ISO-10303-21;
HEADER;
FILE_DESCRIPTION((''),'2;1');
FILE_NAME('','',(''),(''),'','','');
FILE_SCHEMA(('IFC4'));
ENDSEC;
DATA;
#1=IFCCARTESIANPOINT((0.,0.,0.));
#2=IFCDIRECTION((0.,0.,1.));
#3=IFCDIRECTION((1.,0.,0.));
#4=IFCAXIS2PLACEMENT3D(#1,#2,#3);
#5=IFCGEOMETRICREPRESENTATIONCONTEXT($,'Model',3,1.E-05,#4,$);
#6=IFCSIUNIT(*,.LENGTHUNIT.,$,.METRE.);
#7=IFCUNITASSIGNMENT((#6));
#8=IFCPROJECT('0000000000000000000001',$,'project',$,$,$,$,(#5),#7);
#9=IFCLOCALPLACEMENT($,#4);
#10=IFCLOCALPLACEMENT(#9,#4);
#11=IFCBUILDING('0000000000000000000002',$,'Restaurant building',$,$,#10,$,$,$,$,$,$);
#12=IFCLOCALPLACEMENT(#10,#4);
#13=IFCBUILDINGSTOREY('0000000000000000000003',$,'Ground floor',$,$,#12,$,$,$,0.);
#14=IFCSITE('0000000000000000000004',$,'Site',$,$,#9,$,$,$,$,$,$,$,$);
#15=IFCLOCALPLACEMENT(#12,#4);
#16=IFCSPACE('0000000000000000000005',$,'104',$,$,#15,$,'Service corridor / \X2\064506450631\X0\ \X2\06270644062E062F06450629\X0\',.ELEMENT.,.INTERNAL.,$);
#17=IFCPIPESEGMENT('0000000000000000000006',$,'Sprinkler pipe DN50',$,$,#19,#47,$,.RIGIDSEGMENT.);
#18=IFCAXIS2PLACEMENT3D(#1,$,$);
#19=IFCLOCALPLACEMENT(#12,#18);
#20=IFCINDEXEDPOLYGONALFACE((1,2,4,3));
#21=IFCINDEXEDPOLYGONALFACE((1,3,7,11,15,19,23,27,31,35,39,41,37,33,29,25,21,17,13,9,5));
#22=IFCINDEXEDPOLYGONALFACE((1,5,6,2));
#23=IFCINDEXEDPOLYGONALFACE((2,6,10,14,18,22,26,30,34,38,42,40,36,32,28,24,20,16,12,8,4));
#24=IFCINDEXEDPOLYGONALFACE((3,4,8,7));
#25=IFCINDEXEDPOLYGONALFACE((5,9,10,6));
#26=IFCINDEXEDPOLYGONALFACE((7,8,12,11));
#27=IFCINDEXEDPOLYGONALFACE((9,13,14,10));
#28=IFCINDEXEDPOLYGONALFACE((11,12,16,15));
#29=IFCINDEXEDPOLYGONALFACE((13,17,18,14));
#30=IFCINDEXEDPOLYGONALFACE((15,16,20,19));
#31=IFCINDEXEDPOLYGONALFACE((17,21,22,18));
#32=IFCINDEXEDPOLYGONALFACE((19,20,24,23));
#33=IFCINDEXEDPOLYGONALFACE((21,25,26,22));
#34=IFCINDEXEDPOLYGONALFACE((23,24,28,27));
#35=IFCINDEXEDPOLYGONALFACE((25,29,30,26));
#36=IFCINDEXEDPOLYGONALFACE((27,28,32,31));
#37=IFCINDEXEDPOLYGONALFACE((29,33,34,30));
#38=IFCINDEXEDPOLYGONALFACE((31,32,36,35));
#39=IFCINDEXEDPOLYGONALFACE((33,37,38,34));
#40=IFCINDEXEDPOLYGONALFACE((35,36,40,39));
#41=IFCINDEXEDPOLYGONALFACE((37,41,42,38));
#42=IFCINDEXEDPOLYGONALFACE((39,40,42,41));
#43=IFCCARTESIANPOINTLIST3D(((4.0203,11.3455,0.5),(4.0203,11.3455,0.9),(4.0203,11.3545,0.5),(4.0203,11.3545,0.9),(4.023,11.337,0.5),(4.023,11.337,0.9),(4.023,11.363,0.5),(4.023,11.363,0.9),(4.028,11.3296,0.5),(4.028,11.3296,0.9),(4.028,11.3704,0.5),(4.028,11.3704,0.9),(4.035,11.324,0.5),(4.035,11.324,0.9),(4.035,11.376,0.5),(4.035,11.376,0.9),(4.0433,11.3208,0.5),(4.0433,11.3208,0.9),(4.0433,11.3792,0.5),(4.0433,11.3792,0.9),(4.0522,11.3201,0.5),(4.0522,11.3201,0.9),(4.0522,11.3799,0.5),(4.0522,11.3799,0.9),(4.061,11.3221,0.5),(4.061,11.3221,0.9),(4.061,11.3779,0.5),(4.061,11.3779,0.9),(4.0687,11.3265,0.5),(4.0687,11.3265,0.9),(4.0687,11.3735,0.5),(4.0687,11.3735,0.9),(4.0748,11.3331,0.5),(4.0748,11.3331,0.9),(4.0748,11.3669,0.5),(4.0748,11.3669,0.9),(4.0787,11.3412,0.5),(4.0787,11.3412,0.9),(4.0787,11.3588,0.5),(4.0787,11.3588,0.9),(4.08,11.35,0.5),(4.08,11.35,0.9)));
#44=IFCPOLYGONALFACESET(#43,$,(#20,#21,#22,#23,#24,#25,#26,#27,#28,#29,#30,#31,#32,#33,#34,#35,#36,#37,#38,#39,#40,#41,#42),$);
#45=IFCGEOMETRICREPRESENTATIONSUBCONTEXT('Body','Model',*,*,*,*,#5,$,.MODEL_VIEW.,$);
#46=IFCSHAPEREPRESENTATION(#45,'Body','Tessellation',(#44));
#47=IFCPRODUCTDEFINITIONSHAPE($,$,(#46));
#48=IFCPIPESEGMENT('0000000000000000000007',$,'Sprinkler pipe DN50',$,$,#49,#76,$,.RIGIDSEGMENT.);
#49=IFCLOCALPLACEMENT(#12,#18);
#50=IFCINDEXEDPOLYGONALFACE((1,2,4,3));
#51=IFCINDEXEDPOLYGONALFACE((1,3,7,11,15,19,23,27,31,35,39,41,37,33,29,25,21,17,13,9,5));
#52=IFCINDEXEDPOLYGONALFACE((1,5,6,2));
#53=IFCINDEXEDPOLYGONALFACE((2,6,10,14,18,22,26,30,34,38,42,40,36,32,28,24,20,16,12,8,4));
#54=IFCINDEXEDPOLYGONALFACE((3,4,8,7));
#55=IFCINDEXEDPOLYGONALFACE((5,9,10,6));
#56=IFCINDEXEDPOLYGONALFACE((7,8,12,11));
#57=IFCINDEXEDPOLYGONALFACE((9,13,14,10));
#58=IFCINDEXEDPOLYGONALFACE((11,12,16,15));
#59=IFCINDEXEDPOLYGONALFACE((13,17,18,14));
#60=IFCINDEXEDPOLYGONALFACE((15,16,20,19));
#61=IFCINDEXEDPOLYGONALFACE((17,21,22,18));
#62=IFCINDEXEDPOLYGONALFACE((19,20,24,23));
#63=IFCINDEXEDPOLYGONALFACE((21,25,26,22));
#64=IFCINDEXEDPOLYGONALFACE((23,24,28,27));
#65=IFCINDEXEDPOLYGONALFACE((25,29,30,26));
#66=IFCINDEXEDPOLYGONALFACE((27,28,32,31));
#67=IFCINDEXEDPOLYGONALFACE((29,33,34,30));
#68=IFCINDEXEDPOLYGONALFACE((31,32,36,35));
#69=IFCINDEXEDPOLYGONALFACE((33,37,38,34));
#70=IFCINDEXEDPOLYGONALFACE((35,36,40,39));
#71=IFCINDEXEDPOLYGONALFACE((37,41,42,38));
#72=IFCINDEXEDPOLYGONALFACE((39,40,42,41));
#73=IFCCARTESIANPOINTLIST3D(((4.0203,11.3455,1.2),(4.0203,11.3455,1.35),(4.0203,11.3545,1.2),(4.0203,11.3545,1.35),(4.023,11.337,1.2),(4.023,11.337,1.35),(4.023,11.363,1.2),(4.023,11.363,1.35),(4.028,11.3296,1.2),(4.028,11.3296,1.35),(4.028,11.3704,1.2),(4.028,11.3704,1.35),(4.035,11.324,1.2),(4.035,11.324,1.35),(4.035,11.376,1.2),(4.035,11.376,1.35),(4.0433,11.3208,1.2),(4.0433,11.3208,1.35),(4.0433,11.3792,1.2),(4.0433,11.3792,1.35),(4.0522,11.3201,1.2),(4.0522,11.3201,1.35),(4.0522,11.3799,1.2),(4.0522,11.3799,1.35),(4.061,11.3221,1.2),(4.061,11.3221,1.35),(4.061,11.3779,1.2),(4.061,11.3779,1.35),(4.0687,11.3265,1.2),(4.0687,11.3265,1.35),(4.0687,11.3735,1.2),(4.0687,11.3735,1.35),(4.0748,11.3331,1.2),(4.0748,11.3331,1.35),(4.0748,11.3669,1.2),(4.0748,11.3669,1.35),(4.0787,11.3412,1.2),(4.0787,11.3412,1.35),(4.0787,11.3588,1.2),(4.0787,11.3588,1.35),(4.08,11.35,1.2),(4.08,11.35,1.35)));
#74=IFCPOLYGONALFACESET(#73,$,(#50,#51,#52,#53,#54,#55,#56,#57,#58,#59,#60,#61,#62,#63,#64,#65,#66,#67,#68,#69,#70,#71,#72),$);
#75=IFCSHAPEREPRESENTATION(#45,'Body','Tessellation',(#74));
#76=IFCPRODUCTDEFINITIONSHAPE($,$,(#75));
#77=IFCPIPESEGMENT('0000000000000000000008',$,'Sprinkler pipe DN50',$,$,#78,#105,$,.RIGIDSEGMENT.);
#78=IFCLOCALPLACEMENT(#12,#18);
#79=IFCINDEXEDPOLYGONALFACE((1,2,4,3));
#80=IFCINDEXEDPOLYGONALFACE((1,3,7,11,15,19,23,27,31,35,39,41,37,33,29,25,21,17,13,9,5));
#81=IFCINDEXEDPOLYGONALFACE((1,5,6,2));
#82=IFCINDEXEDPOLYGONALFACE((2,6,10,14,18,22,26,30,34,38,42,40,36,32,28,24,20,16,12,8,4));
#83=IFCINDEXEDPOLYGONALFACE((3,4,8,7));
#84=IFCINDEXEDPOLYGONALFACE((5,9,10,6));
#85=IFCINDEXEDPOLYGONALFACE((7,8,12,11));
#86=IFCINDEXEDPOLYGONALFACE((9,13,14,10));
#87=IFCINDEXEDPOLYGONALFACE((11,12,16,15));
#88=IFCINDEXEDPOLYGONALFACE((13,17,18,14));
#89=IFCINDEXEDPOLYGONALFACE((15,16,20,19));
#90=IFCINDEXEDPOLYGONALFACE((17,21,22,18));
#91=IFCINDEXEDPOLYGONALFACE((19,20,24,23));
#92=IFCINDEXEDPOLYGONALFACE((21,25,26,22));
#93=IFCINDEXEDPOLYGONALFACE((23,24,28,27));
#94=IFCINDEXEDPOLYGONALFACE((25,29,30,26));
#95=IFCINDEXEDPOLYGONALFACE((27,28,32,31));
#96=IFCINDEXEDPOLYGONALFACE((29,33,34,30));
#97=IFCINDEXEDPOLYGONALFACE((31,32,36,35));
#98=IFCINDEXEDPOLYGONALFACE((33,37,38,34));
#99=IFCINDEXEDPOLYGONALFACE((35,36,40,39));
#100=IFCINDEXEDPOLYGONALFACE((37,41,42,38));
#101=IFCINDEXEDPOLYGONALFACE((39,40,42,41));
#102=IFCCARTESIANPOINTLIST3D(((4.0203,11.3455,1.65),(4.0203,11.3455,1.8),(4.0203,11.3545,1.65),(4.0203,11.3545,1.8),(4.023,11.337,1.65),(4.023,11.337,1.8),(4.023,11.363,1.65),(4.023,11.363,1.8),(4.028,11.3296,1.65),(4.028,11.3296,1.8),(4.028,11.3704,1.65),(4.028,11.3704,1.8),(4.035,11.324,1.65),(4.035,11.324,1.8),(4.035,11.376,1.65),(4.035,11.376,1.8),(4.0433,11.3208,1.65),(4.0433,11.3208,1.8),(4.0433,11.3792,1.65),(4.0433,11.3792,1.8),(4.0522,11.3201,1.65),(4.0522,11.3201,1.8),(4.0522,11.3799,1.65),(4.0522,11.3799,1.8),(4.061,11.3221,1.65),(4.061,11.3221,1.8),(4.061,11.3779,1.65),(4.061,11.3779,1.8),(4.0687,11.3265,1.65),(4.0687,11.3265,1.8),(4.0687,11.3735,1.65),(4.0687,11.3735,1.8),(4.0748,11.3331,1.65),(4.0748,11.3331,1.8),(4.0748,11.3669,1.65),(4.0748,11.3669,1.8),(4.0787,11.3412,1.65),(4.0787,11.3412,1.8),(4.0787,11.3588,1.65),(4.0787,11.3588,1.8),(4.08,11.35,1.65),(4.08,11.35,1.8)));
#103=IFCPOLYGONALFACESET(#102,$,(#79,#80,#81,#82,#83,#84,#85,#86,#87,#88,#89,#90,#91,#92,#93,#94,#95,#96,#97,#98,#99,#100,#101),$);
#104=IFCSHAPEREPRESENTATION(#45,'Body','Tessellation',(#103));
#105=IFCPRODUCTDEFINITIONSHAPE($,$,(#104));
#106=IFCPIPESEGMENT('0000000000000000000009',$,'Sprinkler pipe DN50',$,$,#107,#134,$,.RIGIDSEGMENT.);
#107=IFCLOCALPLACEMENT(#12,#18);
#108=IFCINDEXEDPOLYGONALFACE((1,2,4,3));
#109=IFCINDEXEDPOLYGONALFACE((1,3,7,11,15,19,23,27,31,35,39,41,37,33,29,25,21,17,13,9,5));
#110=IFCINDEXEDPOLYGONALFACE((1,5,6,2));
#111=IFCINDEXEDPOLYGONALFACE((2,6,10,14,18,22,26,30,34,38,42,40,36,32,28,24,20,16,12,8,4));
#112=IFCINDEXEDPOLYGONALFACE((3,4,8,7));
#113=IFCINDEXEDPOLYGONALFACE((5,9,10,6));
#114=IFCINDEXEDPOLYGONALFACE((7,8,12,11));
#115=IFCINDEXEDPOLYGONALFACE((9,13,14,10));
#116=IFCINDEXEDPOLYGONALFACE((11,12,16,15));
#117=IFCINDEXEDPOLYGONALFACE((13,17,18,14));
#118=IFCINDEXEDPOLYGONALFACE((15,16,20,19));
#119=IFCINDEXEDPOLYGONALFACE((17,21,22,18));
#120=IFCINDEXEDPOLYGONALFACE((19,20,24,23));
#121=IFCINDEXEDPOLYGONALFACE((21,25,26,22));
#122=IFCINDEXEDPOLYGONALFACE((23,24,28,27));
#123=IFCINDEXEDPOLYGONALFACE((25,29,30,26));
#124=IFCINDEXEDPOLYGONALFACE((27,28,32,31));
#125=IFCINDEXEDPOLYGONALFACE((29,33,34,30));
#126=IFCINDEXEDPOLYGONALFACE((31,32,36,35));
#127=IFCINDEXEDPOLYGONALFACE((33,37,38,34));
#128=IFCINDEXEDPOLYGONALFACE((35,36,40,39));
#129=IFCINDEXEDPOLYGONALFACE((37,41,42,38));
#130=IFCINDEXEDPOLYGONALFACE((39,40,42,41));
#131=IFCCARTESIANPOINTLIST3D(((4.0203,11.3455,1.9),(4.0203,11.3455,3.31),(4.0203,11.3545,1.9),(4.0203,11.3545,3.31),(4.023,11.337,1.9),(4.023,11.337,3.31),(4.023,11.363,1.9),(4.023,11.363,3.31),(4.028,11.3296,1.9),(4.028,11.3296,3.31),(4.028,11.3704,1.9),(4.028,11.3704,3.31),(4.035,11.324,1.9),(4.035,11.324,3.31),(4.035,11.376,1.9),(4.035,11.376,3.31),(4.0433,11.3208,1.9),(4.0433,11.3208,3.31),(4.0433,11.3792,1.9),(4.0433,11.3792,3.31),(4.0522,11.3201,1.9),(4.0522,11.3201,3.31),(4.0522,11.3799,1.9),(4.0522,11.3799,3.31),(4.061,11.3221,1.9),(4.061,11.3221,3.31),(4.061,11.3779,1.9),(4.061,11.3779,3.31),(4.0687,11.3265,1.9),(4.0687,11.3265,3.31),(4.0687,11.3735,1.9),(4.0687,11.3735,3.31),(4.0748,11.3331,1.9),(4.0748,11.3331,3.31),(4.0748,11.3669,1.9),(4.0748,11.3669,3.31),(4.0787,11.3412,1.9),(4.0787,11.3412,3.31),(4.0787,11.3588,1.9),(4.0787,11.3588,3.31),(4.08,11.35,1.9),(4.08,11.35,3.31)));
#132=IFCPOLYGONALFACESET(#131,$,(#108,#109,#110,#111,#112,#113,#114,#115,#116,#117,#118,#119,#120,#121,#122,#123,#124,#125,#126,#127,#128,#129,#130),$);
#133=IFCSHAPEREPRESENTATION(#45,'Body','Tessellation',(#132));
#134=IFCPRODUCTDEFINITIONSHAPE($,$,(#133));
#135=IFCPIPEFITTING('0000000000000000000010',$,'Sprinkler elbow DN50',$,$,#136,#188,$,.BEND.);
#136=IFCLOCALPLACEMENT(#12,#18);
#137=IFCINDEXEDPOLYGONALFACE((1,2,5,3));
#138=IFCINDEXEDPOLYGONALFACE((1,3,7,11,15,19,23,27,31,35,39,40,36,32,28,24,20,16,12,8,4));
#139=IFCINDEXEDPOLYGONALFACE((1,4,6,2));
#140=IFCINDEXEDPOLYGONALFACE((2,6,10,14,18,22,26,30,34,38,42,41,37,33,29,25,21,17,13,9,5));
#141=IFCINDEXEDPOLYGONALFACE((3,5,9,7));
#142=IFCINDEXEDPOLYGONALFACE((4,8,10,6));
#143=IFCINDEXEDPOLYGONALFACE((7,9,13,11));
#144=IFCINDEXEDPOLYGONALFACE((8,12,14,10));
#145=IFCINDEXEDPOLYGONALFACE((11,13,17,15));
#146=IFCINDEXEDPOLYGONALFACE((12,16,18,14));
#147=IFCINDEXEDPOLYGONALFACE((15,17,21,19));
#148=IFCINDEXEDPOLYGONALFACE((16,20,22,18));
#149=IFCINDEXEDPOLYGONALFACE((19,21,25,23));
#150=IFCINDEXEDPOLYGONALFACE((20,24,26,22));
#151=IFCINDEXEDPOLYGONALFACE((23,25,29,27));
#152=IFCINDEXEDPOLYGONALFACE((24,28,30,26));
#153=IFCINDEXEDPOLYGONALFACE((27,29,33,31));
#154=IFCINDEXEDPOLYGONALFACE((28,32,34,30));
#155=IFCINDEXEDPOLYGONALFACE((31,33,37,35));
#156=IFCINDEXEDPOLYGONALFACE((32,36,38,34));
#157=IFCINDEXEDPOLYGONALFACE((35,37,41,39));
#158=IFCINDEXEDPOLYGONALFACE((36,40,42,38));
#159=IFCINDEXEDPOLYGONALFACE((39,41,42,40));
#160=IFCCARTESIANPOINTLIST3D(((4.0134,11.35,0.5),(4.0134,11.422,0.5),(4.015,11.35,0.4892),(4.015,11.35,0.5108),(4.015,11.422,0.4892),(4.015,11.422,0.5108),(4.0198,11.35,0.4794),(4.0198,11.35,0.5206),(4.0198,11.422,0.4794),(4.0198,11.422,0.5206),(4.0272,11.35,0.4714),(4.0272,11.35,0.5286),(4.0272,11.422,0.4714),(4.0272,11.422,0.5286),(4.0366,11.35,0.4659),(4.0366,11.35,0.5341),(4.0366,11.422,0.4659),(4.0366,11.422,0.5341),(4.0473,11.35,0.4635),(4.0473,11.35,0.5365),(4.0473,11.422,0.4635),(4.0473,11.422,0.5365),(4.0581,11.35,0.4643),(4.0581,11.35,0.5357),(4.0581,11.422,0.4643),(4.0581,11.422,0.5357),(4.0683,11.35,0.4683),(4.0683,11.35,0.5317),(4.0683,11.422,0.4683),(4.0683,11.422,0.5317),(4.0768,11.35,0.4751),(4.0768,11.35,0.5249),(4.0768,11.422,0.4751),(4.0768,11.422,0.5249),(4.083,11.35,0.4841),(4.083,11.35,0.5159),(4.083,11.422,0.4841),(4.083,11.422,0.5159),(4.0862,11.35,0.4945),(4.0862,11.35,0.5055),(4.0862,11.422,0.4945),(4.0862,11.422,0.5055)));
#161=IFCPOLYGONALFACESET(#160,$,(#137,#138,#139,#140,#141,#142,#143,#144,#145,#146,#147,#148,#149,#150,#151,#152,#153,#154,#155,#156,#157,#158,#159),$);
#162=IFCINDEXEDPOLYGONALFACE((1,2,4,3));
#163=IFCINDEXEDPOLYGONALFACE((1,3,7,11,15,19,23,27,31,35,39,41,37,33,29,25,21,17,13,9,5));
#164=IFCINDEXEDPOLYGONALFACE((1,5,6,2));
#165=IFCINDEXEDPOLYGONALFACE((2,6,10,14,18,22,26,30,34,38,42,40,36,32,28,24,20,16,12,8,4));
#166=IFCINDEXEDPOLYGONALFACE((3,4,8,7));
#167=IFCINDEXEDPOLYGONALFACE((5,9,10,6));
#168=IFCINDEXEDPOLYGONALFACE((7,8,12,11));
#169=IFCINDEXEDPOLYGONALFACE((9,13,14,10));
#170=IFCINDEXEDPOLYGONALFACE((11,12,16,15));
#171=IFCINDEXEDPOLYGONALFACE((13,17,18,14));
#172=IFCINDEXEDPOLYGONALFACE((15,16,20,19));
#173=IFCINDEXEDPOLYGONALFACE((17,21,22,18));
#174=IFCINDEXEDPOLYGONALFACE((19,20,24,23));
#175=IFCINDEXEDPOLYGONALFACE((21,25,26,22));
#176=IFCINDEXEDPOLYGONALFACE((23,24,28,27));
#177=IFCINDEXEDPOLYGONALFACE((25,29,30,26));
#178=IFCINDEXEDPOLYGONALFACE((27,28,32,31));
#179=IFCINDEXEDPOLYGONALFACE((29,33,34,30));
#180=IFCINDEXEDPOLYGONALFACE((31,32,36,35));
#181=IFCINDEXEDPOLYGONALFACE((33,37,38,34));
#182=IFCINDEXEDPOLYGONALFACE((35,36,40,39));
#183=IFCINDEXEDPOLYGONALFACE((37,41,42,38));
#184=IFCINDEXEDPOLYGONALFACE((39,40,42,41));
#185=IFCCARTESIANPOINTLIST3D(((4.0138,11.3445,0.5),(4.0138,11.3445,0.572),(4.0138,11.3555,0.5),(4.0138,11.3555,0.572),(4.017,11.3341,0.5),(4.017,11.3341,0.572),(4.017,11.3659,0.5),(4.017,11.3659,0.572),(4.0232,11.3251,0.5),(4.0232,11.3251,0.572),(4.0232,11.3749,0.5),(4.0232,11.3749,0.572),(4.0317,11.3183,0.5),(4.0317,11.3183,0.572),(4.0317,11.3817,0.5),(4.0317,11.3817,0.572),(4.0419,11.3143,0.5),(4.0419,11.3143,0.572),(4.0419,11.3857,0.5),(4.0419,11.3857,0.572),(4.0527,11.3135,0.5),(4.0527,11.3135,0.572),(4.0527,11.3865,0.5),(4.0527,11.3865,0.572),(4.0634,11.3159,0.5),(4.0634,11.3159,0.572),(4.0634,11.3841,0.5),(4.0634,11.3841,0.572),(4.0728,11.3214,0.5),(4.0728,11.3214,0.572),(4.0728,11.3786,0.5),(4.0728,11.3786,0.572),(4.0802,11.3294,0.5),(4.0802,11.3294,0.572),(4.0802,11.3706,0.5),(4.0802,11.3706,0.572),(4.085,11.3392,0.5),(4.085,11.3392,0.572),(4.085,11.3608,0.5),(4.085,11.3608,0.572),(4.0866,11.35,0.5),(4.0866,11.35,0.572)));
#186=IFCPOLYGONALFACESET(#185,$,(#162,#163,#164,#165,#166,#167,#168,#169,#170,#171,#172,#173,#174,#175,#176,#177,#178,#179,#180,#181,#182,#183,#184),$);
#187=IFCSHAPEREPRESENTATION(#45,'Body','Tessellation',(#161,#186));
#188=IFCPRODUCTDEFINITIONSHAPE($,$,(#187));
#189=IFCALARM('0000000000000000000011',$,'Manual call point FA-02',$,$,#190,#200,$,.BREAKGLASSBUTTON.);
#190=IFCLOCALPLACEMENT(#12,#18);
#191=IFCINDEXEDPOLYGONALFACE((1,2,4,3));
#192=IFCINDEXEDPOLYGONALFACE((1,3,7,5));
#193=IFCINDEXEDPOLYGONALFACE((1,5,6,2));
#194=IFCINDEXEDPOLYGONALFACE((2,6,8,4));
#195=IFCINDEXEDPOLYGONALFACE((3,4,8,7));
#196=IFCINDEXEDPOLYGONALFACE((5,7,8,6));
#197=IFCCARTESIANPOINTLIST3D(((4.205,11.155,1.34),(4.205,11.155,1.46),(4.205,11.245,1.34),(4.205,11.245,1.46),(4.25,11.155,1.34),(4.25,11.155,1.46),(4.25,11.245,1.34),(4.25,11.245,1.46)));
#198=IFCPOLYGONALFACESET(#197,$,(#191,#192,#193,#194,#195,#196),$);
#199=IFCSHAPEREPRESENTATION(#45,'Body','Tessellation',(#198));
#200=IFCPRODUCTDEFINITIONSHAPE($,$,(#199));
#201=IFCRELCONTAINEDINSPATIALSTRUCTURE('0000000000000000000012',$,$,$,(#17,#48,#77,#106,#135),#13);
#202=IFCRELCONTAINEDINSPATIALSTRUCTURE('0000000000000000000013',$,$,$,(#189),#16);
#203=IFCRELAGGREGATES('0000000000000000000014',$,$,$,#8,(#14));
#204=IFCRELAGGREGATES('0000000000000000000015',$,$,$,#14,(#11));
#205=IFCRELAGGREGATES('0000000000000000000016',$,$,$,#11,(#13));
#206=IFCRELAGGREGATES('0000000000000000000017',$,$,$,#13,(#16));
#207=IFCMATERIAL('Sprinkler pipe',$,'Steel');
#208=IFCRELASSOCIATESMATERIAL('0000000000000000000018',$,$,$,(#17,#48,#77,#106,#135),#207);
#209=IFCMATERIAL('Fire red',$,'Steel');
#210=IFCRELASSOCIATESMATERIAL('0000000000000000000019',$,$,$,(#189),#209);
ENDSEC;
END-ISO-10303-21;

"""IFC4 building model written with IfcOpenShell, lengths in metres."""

from ifc_helpers import new_model, si_unit, frame, origin, origin_with_axes, origin_2d, place, context, subcontext, project, spatial, rectangle, circle, extrude, material, element, save


model = new_model("IFC4")

# Units and contexts
model_context = context("Model", 3, precision=1e-05, world=origin_with_axes())
body_context = subcontext(model_context, "Body", "Model", "MODEL_VIEW")
ifc_project = project(units=[si_unit("LENGTHUNIT", "METRE")], contexts=[model_context])

# Site, building, storey
site_placement = place(None, origin_with_axes())
site = spatial("IfcSite", under=ifc_project, at=site_placement, Name="Site")
building_placement = place(site_placement, origin_with_axes())
building = spatial("IfcBuilding", under=site, at=building_placement, Name="Restaurant building")
storey_placement = place(building_placement, origin_with_axes())
storey = spatial("IfcBuildingStorey", under=building, at=storey_placement, Name="Ground floor", Elevation=0.0)

# Shared definitions
space_1_placement = place(storey_placement, origin_with_axes())
space_1 = spatial("IfcSpace", under=storey, at=space_1_placement, Name="104", LongName="Service corridor / ممر الخدمة", CompositionType="ELEMENT", PredefinedType="INTERNAL")

# Shared definitions
ifc_material_1 = material(Name="Fire red", Category="Steel")

# Pipe segments
ifc_material_2 = material(Name="Sprinkler pipe", Category="Steel")
pipe_segment_1_placement = place(storey_placement, frame((4.05, 11.35, 0.5)))
element("IfcPipeSegment", 1, at=pipe_segment_1_placement, inside=storey, material=ifc_material_2, Name="Sprinkler pipe DN50", PredefinedType="RIGIDSEGMENT", context=body_context, shape_type="SweptSolid", body=[
    extrude(circle(Radius=0.03, at=origin_2d()), origin(), (0.0, 0.0, 1.0), 0.4),
])
for number, where, name in (
    (2, (4.05, 11.35, 1.2), "Sprinkler pipe DN50"),
    (3, (4.05, 11.35, 1.65), "Sprinkler pipe DN50"),
):
    element("IfcPipeSegment", number, at=place(storey_placement, frame(where)), inside=storey, material=ifc_material_2, Name=name, PredefinedType="RIGIDSEGMENT", context=body_context, shape_type="SweptSolid", body=[
        extrude(circle(Radius=0.03, at=origin_2d()), origin(), (0.0, 0.0, 1.0), 0.15),
    ])
pipe_segment_2_placement = place(storey_placement, frame((4.05, 11.35, 1.9)))
element("IfcPipeSegment", 4, at=pipe_segment_2_placement, inside=storey, material=ifc_material_2, Name="Sprinkler pipe DN50", PredefinedType="RIGIDSEGMENT", context=body_context, shape_type="SweptSolid", body=[
    extrude(circle(Radius=0.03, at=origin_2d()), origin(), (0.0, 0.0, 1.0), 1.41),
])

# Pipe fitting
pipe_fitting_1_placement = place(storey_placement, frame((4.05, 11.35, 0.5)))
element("IfcPipeFitting", 5, at=pipe_fitting_1_placement, inside=storey, material=ifc_material_2, Name="Sprinkler elbow DN50", PredefinedType="BEND", context=body_context, shape_type="SweptSolid", body=[
    extrude(circle(Radius=0.0366, at=origin_2d()), frame((0.0, 0.0, 0.0), z_axis=(0.0, 1.0, 0.0), x_axis=(-1.0, 0.0, 0.0)), (0.0, 0.0, 1.0), 0.072),
    extrude(circle(Radius=0.0366, at=origin_2d()), origin(), (0.0, 0.0, 1.0), 0.072),
])

# Alarm
alarm_placement = place(storey_placement, frame((4.25, 11.2, 1.4)))
element("IfcAlarm", 6, at=alarm_placement, inside=space_1, material=ifc_material_1, Name="Manual call point FA-02", PredefinedType="BREAKGLASSBUTTON", context=body_context, shape_type="SweptSolid", body=[
    extrude(rectangle(XDim=0.045, YDim=0.09, at=origin_2d()), frame((-0.0225, 0.0, -0.06)), (0.0, 0.0, 1.0), 0.12),
])

save(model, "model.ifc")
